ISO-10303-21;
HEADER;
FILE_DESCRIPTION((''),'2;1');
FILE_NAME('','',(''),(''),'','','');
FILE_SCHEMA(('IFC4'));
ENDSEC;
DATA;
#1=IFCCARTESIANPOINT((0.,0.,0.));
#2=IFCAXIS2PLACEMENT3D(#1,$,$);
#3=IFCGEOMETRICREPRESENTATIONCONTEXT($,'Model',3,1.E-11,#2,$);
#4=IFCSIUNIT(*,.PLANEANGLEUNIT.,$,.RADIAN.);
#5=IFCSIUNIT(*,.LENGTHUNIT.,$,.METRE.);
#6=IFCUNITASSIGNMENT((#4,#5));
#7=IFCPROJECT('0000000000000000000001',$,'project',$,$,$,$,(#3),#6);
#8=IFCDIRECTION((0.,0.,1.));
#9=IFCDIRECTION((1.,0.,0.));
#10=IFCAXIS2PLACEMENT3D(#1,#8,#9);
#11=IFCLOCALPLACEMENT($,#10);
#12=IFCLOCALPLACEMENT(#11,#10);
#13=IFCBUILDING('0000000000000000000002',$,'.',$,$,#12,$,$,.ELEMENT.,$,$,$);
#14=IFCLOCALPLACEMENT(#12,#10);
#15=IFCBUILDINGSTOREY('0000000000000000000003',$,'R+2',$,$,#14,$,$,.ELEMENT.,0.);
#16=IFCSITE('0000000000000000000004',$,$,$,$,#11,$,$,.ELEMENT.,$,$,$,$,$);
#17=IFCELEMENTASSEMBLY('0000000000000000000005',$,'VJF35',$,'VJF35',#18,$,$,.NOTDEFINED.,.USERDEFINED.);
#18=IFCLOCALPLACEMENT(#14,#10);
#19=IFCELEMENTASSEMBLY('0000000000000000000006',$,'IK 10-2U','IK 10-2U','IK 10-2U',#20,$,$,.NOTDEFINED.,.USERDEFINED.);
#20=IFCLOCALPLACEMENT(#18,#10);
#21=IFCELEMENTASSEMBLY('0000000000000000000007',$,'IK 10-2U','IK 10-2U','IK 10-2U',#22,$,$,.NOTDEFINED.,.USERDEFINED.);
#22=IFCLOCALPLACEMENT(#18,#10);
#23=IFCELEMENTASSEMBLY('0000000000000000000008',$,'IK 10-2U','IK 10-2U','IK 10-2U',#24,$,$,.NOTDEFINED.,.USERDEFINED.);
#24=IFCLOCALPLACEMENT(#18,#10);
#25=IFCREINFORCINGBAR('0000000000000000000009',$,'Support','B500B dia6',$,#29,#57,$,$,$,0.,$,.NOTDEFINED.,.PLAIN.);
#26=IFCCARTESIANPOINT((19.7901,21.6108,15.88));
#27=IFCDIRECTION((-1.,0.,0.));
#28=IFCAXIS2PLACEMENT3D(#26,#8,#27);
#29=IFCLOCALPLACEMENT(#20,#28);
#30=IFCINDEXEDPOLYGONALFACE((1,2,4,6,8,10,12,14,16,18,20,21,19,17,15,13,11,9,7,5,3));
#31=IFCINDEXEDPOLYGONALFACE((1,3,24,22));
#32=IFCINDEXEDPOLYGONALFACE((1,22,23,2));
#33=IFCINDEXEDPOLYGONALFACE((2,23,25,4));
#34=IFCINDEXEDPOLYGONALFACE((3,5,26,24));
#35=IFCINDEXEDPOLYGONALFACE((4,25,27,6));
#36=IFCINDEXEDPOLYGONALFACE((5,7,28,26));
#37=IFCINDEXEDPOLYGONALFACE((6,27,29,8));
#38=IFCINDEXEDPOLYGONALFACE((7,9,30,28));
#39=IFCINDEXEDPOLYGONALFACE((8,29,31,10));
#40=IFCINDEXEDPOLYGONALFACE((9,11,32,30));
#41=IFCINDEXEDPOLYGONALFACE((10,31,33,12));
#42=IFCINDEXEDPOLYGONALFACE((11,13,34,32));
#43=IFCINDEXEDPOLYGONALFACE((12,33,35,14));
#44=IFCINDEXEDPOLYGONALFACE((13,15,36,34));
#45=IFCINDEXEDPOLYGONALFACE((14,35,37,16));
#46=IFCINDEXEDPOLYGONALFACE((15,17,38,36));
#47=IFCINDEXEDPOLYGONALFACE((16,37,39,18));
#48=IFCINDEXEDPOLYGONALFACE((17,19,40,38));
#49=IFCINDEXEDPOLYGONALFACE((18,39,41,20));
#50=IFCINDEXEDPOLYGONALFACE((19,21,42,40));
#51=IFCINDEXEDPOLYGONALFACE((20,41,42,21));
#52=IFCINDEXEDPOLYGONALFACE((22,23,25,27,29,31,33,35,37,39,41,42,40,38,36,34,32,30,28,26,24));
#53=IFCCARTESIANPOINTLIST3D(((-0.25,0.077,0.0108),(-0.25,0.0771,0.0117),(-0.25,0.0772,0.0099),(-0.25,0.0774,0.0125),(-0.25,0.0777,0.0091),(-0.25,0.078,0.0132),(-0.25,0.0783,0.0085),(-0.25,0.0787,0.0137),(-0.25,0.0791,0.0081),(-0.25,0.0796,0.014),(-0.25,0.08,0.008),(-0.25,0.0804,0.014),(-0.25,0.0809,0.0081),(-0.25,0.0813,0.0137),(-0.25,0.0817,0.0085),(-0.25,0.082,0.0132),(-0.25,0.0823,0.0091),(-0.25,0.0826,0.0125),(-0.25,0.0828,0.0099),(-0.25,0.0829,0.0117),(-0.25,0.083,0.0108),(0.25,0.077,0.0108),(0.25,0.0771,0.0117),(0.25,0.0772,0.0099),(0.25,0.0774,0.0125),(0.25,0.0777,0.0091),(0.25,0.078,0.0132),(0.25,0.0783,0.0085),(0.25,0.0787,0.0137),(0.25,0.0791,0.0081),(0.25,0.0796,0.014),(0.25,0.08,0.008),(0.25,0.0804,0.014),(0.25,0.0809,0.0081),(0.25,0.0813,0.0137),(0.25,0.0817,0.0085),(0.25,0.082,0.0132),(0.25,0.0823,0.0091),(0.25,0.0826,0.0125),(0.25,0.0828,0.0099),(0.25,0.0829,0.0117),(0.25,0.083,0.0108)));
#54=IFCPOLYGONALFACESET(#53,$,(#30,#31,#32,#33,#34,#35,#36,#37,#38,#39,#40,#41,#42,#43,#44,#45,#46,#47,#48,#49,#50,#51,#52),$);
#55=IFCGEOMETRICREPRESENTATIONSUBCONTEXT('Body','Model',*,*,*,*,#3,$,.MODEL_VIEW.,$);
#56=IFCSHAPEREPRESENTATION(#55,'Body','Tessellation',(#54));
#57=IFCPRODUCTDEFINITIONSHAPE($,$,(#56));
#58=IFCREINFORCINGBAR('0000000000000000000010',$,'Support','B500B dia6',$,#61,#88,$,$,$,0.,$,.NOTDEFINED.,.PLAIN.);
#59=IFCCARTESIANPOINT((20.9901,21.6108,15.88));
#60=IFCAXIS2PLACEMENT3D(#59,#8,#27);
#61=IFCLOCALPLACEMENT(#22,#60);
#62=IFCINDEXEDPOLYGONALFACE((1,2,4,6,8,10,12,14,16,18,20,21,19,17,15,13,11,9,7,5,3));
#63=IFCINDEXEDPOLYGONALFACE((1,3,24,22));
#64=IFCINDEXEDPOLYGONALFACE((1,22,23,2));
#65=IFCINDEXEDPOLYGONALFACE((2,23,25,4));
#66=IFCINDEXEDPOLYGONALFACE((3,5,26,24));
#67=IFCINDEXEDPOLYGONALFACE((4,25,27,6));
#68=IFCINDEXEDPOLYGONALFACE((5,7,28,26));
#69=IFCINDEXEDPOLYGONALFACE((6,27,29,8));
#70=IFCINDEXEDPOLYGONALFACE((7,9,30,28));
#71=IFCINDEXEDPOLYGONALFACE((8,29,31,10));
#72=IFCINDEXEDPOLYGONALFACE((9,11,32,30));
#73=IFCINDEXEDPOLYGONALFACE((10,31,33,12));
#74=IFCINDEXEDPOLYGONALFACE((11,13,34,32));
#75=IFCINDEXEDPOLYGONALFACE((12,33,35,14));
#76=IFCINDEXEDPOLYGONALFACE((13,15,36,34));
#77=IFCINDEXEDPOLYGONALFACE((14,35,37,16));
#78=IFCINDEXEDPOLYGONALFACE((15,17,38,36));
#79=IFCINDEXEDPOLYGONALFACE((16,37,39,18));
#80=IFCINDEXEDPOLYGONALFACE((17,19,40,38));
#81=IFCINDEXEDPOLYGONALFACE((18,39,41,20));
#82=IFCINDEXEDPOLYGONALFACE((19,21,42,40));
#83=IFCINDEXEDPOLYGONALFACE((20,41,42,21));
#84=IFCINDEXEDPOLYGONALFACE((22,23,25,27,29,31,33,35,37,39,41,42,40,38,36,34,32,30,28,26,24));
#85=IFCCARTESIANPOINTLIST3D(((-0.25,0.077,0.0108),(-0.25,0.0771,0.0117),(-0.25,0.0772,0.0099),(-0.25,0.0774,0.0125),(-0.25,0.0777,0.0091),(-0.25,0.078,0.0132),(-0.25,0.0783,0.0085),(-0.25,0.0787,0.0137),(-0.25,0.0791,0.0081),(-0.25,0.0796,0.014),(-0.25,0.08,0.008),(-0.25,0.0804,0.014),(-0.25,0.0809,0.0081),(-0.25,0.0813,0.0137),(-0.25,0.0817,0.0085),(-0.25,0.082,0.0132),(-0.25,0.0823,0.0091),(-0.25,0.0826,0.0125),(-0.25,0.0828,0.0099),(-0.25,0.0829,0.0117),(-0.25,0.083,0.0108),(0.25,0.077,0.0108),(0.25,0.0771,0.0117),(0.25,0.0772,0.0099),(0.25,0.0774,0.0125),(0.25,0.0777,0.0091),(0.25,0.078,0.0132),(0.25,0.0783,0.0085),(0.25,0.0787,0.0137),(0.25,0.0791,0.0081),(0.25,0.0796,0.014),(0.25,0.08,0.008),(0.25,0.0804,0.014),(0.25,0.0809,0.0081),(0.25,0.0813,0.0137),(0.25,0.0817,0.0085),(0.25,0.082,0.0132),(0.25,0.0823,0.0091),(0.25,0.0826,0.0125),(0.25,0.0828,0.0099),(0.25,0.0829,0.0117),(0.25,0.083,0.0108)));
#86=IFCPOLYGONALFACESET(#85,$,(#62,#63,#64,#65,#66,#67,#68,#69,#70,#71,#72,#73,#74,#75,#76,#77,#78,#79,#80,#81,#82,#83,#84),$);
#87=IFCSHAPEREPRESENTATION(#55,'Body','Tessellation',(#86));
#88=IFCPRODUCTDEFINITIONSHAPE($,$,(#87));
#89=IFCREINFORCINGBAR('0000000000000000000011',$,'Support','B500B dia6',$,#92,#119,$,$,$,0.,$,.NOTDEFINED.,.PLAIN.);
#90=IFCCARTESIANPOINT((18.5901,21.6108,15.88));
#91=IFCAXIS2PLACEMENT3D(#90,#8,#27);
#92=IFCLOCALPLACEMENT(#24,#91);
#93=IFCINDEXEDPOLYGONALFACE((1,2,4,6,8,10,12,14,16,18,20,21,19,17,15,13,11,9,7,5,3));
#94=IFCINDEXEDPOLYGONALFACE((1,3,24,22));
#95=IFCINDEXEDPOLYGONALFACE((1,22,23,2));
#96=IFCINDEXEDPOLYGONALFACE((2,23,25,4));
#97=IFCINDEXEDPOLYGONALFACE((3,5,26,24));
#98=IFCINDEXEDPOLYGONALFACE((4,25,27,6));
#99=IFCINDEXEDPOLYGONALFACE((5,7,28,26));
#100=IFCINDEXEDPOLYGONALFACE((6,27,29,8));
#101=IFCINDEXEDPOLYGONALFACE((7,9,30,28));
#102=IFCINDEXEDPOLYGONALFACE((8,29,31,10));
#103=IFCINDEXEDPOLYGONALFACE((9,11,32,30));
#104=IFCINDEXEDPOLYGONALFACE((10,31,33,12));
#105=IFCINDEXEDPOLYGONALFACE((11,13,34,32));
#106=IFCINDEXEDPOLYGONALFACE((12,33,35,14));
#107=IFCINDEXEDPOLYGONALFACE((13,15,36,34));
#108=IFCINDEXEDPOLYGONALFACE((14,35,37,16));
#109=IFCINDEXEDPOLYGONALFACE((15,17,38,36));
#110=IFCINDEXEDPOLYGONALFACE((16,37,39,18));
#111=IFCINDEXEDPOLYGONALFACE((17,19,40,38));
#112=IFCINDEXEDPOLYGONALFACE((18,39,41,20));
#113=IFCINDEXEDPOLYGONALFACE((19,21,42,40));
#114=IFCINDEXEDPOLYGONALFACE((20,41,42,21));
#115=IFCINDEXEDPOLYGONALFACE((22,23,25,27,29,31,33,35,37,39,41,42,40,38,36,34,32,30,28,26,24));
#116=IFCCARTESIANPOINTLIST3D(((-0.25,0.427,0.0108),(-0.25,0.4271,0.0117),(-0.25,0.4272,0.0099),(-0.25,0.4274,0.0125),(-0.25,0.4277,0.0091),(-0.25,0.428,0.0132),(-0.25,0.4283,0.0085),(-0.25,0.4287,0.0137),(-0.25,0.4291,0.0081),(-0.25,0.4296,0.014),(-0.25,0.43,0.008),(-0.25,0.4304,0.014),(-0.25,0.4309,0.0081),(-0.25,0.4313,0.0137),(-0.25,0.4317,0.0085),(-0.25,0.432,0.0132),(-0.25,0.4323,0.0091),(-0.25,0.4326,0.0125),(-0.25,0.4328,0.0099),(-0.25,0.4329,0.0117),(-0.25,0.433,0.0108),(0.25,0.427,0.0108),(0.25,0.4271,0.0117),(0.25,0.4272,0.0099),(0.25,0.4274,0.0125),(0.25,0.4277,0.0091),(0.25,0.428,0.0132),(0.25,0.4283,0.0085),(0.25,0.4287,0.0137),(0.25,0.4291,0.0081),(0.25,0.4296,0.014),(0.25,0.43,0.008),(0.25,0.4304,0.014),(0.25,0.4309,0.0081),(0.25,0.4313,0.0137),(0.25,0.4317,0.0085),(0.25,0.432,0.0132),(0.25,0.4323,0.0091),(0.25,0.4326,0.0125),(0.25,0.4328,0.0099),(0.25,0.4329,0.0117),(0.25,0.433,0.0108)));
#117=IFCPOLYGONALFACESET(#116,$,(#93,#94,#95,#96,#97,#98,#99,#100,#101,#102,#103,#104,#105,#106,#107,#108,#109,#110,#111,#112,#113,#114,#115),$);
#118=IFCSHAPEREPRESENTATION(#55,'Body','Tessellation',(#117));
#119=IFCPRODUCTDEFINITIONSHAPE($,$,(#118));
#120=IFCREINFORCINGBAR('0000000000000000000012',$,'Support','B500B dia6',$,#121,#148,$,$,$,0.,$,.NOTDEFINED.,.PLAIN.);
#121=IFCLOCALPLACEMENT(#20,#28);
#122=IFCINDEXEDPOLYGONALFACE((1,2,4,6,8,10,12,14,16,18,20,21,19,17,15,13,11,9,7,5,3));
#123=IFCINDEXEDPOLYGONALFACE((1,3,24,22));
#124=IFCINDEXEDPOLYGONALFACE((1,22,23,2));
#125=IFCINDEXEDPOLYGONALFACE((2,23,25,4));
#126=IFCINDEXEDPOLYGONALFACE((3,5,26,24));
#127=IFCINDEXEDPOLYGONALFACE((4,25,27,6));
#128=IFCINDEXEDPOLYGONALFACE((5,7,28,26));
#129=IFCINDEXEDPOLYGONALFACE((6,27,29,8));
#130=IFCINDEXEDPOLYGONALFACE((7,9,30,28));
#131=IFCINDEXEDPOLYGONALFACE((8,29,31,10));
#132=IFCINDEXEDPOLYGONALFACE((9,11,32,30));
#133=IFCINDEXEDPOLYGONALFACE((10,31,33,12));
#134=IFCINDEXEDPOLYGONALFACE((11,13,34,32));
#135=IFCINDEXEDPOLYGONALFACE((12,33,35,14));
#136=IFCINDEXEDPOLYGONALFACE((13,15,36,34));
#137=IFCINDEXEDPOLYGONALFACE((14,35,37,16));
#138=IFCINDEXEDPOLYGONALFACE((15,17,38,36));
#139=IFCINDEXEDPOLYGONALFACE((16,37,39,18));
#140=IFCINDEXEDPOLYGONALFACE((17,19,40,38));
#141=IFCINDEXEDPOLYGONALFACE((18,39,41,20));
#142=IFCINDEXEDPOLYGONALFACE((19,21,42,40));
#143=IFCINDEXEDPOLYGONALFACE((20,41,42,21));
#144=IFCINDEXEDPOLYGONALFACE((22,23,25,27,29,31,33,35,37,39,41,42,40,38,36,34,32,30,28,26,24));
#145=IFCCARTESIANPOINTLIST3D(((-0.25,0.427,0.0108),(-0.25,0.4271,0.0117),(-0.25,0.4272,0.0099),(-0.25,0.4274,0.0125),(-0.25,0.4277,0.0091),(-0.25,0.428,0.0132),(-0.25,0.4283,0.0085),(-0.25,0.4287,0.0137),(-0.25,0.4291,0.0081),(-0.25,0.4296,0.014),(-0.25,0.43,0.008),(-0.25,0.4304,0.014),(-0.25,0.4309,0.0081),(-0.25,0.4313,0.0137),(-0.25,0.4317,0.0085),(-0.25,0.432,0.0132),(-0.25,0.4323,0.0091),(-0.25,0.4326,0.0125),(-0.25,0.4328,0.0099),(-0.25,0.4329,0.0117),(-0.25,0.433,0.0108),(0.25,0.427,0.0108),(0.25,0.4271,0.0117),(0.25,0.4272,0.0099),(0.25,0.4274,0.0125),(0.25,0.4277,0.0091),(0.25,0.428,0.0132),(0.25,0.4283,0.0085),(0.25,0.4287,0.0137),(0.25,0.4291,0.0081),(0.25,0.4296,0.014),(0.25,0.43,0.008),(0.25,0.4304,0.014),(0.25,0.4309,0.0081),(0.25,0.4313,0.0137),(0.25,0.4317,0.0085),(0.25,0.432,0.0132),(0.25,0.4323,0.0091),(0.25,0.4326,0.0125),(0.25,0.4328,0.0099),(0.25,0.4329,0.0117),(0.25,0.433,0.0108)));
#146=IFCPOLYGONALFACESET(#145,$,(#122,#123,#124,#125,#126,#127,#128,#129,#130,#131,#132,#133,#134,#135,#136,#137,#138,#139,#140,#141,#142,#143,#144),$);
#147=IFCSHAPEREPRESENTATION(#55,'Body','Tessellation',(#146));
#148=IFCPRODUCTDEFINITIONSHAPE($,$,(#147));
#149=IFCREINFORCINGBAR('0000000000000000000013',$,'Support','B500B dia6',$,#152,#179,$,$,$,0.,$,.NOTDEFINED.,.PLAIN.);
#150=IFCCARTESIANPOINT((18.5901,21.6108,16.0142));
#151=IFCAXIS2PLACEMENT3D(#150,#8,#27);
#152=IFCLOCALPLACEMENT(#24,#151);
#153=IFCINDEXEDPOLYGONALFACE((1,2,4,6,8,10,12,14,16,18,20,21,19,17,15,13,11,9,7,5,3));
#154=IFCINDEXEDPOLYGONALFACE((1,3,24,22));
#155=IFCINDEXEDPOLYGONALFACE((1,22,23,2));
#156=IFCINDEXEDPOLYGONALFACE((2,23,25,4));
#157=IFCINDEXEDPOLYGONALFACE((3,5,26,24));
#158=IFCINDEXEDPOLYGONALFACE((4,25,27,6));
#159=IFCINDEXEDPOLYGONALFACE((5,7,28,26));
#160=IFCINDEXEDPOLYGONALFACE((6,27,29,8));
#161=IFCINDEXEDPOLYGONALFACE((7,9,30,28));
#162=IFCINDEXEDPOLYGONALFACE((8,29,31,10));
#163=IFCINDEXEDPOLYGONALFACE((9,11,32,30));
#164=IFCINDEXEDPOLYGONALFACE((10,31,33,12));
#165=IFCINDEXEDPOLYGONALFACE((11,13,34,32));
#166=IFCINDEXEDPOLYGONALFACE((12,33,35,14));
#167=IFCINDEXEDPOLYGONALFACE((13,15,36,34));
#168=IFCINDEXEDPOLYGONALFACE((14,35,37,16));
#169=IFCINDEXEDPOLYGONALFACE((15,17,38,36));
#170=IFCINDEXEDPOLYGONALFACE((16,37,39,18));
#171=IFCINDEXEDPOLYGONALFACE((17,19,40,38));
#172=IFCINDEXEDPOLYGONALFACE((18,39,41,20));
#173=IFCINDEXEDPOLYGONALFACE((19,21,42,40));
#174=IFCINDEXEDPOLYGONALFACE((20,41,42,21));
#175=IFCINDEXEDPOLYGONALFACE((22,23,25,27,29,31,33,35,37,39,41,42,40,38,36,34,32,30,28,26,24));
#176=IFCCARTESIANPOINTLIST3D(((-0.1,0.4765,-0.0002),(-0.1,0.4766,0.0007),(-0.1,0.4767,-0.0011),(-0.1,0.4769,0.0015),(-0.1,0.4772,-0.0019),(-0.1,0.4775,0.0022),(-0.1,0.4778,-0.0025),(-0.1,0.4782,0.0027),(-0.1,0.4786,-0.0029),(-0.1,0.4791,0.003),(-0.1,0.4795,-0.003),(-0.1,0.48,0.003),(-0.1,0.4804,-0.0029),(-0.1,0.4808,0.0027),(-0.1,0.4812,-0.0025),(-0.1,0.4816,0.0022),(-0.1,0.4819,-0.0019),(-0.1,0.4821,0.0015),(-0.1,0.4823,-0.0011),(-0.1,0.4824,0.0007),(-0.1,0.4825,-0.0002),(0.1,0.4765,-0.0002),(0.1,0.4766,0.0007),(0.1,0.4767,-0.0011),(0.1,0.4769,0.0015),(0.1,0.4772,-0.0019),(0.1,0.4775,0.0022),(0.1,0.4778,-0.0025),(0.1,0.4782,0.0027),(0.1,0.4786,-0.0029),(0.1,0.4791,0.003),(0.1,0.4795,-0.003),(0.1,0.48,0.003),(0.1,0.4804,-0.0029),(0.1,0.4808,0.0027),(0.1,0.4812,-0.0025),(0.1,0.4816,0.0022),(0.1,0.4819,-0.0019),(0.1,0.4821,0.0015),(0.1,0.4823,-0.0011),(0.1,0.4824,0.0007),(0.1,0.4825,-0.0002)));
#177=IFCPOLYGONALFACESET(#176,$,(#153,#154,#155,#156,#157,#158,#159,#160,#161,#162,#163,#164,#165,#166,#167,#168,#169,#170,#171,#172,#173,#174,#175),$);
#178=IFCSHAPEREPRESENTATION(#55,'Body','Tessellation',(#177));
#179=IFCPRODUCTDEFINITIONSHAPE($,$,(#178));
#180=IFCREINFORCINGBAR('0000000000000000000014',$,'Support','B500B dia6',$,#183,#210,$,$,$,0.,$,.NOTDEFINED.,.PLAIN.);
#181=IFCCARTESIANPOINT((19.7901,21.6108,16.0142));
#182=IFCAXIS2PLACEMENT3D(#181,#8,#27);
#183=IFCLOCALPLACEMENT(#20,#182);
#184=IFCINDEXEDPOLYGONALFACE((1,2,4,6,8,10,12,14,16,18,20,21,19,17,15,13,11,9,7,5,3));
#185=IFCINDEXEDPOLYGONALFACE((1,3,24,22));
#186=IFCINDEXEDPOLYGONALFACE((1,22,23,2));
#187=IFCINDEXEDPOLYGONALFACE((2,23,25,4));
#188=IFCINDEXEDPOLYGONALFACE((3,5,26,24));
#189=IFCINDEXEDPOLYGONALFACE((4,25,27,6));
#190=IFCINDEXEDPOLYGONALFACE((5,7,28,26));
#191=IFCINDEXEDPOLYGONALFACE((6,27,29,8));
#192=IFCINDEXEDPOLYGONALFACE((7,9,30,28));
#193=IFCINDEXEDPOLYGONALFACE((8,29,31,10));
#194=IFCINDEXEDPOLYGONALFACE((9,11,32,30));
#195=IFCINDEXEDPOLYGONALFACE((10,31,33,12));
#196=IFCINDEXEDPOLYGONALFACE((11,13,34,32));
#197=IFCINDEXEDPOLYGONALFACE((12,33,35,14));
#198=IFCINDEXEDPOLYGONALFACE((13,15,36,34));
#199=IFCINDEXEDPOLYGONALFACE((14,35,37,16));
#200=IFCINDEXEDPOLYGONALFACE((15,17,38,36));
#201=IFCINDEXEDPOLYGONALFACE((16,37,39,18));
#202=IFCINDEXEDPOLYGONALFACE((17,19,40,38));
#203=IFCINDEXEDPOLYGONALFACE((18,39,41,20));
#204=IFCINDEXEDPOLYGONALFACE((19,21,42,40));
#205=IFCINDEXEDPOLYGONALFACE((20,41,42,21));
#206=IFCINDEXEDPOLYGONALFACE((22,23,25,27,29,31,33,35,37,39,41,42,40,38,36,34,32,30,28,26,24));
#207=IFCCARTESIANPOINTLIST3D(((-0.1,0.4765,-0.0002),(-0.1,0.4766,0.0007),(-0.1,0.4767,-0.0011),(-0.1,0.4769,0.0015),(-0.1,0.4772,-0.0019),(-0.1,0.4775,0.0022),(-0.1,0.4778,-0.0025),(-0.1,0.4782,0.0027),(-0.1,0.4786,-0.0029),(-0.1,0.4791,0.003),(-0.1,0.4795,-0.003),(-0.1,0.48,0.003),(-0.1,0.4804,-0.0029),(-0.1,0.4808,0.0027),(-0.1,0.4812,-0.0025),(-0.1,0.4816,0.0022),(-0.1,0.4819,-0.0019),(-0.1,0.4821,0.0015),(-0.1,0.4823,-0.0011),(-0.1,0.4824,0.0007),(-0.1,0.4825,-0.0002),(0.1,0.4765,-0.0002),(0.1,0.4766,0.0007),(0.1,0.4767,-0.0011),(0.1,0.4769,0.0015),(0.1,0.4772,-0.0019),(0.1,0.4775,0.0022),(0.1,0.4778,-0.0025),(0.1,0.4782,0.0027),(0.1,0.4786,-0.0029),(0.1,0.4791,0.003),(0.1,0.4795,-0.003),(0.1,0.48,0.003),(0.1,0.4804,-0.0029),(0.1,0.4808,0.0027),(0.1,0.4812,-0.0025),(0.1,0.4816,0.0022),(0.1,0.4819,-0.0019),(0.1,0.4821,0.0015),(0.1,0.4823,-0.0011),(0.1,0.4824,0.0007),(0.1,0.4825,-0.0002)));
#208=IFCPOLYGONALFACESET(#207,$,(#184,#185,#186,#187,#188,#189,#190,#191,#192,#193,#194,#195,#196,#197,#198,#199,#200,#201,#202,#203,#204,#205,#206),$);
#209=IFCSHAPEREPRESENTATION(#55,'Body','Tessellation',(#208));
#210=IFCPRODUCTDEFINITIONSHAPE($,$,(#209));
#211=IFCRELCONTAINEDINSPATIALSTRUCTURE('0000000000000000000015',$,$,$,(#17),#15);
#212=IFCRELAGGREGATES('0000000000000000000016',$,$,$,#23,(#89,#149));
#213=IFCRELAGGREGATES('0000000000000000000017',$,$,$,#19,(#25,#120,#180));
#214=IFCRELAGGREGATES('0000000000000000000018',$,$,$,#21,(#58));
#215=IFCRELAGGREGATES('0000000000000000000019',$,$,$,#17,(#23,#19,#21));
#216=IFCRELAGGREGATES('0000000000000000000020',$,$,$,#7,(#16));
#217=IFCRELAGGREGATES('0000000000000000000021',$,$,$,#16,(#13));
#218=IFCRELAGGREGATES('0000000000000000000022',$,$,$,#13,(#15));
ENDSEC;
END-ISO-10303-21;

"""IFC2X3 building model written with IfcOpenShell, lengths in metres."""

from ifc_helpers import new_model, entity, si_unit, frame, origin, origin_with_axes, place, context, subcontext, project, spatial, source, transform, mapped, element, aggregate, save


model = new_model("IFC2X3")

# Units and contexts
model_context = context("Model", 3, precision=1e-11, world=origin())
body_context = subcontext(model_context, "Body", "Model", "MODEL_VIEW")
ifc_project = project(units=[si_unit("PLANEANGLEUNIT", "RADIAN"), si_unit("LENGTHUNIT", "METRE")], contexts=[model_context])

# Site, building, storey
site_placement = place(None, origin_with_axes())
site = spatial("IfcSite", under=ifc_project, at=site_placement, CompositionType="ELEMENT")
building_placement = place(site_placement, origin_with_axes())
building = spatial("IfcBuilding", under=site, at=building_placement, Name=".", CompositionType="ELEMENT")
storey_placement = place(building_placement, origin_with_axes())
storey = spatial("IfcBuildingStorey", under=building, at=storey_placement, Name="R+2", CompositionType="ELEMENT", Elevation=0.0)

# Element assemblies, reinforcing bars
assembly_1_placement = place(storey_placement, origin_with_axes())
assembly_1 = element("IfcElementAssembly", 1, at=assembly_1_placement, inside=storey, Name="VJF35", ObjectType="VJF35", AssemblyPlace="NOTDEFINED", PredefinedType="USERDEFINED")
assembly_2_placement = place(assembly_1_placement, origin_with_axes())
assembly_2 = element("IfcElementAssembly", 2, at=assembly_2_placement, Name="IK 10-2U", Description="IK 10-2U", ObjectType="IK 10-2U", AssemblyPlace="NOTDEFINED", PredefinedType="USERDEFINED")
assembly_3_placement = place(assembly_1_placement, origin_with_axes())
assembly_3 = element("IfcElementAssembly", 3, at=assembly_3_placement, Name="IK 10-2U", Description="IK 10-2U", ObjectType="IK 10-2U", AssemblyPlace="NOTDEFINED", PredefinedType="USERDEFINED")
assembly_4_placement = place(assembly_1_placement, origin_with_axes())
assembly_4 = element("IfcElementAssembly", 4, at=assembly_4_placement, Name="IK 10-2U", Description="IK 10-2U", ObjectType="IK 10-2U", AssemblyPlace="NOTDEFINED", PredefinedType="USERDEFINED")
shared_shape_1 = source(origin_with_axes(), body_context, "Body", "AdvancedSweptSolid", [
    entity("IfcSweptDiskSolid", entity("IfcPolyline", [entity("IfcCartesianPoint", [0.25, 0.08, 0.011]), entity("IfcCartesianPoint", [-0.25, 0.08, 0.011])]), 0.003, None, 0.0, 0.5),
])
reinforcing_bar_1_placement = place(assembly_2_placement, frame((19.7901, 21.6108, 15.88), z_axis=(0.0, 0.0, 1.0), x_axis=(-1.0, 0.0, 0.0)))
reinforcing_bar_1 = element("IfcReinforcingBar", 5, at=reinforcing_bar_1_placement, Name="Support", Description="B500B dia6", BarRole="NOTDEFINED", BarSurface="PLAIN", CrossSectionArea=0.0, context=body_context, shape_type="MappedRepresentation", body=[
    mapped(shared_shape_1, transform((0.0, 0.0, 0.0), scale=1.0)),
])
reinforcing_bar_2_placement = place(assembly_3_placement, frame((20.9901, 21.6108, 15.88), z_axis=(0.0, 0.0, 1.0), x_axis=(-1.0, 0.0, 0.0)))
reinforcing_bar_2 = element("IfcReinforcingBar", 6, at=reinforcing_bar_2_placement, Name="Support", Description="B500B dia6", BarRole="NOTDEFINED", BarSurface="PLAIN", CrossSectionArea=0.0, context=body_context, shape_type="MappedRepresentation", body=[
    mapped(shared_shape_1, transform((0.0, 0.0, 0.0), scale=1.0)),
])
shared_shape_2 = source(origin_with_axes(), body_context, "Body", "AdvancedSweptSolid", [
    entity("IfcSweptDiskSolid", entity("IfcPolyline", [entity("IfcCartesianPoint", [0.25, 0.43, 0.011]), entity("IfcCartesianPoint", [-0.25, 0.43, 0.011])]), 0.003, None, 0.0, 0.5),
])
reinforcing_bar_3_placement = place(assembly_4_placement, frame((18.5901, 21.6108, 15.88), z_axis=(0.0, 0.0, 1.0), x_axis=(-1.0, 0.0, 0.0)))
reinforcing_bar_3 = element("IfcReinforcingBar", 7, at=reinforcing_bar_3_placement, Name="Support", Description="B500B dia6", BarRole="NOTDEFINED", BarSurface="PLAIN", CrossSectionArea=0.0, context=body_context, shape_type="MappedRepresentation", body=[
    mapped(shared_shape_2, transform((0.0, 0.0, 0.0), scale=1.0)),
])
reinforcing_bar_4_placement = place(assembly_2_placement, frame((19.7901, 21.6108, 15.88), z_axis=(0.0, 0.0, 1.0), x_axis=(-1.0, 0.0, 0.0)))
reinforcing_bar_4 = element("IfcReinforcingBar", 8, at=reinforcing_bar_4_placement, Name="Support", Description="B500B dia6", BarRole="NOTDEFINED", BarSurface="PLAIN", CrossSectionArea=0.0, context=body_context, shape_type="MappedRepresentation", body=[
    mapped(shared_shape_2, transform((0.0, 0.0, 0.0), scale=1.0)),
])
shared_shape_3 = source(origin_with_axes(), body_context, "Body", "AdvancedSweptSolid", [
    entity("IfcSweptDiskSolid", entity("IfcPolyline", [entity("IfcCartesianPoint", [0.1, 0.4795, 0.0]), entity("IfcCartesianPoint", [-0.1, 0.4795, 0.0])]), 0.003, None, 0.0, 0.2),
])
reinforcing_bar_5_placement = place(assembly_4_placement, frame((18.5901, 21.6108, 16.0142), z_axis=(0.0, 0.0, 1.0), x_axis=(-1.0, 0.0, 0.0)))
reinforcing_bar_5 = element("IfcReinforcingBar", 9, at=reinforcing_bar_5_placement, Name="Support", Description="B500B dia6", BarRole="NOTDEFINED", BarSurface="PLAIN", CrossSectionArea=0.0, context=body_context, shape_type="MappedRepresentation", body=[
    mapped(shared_shape_3, transform((0.0, 0.0, 0.0), scale=1.0)),
])
reinforcing_bar_6_placement = place(assembly_2_placement, frame((19.7901, 21.6108, 16.0142), z_axis=(0.0, 0.0, 1.0), x_axis=(-1.0, 0.0, 0.0)))
reinforcing_bar_6 = element("IfcReinforcingBar", 10, at=reinforcing_bar_6_placement, Name="Support", Description="B500B dia6", BarRole="NOTDEFINED", BarSurface="PLAIN", CrossSectionArea=0.0, context=body_context, shape_type="MappedRepresentation", body=[
    mapped(shared_shape_3, transform((0.0, 0.0, 0.0), scale=1.0)),
])
aggregate(assembly_4, [reinforcing_bar_3, reinforcing_bar_5])
aggregate(assembly_2, [reinforcing_bar_1, reinforcing_bar_4, reinforcing_bar_6])
aggregate(assembly_3, [reinforcing_bar_2])

aggregate(assembly_1, [assembly_4, assembly_2, assembly_3])

save(model, "model.ifc")
